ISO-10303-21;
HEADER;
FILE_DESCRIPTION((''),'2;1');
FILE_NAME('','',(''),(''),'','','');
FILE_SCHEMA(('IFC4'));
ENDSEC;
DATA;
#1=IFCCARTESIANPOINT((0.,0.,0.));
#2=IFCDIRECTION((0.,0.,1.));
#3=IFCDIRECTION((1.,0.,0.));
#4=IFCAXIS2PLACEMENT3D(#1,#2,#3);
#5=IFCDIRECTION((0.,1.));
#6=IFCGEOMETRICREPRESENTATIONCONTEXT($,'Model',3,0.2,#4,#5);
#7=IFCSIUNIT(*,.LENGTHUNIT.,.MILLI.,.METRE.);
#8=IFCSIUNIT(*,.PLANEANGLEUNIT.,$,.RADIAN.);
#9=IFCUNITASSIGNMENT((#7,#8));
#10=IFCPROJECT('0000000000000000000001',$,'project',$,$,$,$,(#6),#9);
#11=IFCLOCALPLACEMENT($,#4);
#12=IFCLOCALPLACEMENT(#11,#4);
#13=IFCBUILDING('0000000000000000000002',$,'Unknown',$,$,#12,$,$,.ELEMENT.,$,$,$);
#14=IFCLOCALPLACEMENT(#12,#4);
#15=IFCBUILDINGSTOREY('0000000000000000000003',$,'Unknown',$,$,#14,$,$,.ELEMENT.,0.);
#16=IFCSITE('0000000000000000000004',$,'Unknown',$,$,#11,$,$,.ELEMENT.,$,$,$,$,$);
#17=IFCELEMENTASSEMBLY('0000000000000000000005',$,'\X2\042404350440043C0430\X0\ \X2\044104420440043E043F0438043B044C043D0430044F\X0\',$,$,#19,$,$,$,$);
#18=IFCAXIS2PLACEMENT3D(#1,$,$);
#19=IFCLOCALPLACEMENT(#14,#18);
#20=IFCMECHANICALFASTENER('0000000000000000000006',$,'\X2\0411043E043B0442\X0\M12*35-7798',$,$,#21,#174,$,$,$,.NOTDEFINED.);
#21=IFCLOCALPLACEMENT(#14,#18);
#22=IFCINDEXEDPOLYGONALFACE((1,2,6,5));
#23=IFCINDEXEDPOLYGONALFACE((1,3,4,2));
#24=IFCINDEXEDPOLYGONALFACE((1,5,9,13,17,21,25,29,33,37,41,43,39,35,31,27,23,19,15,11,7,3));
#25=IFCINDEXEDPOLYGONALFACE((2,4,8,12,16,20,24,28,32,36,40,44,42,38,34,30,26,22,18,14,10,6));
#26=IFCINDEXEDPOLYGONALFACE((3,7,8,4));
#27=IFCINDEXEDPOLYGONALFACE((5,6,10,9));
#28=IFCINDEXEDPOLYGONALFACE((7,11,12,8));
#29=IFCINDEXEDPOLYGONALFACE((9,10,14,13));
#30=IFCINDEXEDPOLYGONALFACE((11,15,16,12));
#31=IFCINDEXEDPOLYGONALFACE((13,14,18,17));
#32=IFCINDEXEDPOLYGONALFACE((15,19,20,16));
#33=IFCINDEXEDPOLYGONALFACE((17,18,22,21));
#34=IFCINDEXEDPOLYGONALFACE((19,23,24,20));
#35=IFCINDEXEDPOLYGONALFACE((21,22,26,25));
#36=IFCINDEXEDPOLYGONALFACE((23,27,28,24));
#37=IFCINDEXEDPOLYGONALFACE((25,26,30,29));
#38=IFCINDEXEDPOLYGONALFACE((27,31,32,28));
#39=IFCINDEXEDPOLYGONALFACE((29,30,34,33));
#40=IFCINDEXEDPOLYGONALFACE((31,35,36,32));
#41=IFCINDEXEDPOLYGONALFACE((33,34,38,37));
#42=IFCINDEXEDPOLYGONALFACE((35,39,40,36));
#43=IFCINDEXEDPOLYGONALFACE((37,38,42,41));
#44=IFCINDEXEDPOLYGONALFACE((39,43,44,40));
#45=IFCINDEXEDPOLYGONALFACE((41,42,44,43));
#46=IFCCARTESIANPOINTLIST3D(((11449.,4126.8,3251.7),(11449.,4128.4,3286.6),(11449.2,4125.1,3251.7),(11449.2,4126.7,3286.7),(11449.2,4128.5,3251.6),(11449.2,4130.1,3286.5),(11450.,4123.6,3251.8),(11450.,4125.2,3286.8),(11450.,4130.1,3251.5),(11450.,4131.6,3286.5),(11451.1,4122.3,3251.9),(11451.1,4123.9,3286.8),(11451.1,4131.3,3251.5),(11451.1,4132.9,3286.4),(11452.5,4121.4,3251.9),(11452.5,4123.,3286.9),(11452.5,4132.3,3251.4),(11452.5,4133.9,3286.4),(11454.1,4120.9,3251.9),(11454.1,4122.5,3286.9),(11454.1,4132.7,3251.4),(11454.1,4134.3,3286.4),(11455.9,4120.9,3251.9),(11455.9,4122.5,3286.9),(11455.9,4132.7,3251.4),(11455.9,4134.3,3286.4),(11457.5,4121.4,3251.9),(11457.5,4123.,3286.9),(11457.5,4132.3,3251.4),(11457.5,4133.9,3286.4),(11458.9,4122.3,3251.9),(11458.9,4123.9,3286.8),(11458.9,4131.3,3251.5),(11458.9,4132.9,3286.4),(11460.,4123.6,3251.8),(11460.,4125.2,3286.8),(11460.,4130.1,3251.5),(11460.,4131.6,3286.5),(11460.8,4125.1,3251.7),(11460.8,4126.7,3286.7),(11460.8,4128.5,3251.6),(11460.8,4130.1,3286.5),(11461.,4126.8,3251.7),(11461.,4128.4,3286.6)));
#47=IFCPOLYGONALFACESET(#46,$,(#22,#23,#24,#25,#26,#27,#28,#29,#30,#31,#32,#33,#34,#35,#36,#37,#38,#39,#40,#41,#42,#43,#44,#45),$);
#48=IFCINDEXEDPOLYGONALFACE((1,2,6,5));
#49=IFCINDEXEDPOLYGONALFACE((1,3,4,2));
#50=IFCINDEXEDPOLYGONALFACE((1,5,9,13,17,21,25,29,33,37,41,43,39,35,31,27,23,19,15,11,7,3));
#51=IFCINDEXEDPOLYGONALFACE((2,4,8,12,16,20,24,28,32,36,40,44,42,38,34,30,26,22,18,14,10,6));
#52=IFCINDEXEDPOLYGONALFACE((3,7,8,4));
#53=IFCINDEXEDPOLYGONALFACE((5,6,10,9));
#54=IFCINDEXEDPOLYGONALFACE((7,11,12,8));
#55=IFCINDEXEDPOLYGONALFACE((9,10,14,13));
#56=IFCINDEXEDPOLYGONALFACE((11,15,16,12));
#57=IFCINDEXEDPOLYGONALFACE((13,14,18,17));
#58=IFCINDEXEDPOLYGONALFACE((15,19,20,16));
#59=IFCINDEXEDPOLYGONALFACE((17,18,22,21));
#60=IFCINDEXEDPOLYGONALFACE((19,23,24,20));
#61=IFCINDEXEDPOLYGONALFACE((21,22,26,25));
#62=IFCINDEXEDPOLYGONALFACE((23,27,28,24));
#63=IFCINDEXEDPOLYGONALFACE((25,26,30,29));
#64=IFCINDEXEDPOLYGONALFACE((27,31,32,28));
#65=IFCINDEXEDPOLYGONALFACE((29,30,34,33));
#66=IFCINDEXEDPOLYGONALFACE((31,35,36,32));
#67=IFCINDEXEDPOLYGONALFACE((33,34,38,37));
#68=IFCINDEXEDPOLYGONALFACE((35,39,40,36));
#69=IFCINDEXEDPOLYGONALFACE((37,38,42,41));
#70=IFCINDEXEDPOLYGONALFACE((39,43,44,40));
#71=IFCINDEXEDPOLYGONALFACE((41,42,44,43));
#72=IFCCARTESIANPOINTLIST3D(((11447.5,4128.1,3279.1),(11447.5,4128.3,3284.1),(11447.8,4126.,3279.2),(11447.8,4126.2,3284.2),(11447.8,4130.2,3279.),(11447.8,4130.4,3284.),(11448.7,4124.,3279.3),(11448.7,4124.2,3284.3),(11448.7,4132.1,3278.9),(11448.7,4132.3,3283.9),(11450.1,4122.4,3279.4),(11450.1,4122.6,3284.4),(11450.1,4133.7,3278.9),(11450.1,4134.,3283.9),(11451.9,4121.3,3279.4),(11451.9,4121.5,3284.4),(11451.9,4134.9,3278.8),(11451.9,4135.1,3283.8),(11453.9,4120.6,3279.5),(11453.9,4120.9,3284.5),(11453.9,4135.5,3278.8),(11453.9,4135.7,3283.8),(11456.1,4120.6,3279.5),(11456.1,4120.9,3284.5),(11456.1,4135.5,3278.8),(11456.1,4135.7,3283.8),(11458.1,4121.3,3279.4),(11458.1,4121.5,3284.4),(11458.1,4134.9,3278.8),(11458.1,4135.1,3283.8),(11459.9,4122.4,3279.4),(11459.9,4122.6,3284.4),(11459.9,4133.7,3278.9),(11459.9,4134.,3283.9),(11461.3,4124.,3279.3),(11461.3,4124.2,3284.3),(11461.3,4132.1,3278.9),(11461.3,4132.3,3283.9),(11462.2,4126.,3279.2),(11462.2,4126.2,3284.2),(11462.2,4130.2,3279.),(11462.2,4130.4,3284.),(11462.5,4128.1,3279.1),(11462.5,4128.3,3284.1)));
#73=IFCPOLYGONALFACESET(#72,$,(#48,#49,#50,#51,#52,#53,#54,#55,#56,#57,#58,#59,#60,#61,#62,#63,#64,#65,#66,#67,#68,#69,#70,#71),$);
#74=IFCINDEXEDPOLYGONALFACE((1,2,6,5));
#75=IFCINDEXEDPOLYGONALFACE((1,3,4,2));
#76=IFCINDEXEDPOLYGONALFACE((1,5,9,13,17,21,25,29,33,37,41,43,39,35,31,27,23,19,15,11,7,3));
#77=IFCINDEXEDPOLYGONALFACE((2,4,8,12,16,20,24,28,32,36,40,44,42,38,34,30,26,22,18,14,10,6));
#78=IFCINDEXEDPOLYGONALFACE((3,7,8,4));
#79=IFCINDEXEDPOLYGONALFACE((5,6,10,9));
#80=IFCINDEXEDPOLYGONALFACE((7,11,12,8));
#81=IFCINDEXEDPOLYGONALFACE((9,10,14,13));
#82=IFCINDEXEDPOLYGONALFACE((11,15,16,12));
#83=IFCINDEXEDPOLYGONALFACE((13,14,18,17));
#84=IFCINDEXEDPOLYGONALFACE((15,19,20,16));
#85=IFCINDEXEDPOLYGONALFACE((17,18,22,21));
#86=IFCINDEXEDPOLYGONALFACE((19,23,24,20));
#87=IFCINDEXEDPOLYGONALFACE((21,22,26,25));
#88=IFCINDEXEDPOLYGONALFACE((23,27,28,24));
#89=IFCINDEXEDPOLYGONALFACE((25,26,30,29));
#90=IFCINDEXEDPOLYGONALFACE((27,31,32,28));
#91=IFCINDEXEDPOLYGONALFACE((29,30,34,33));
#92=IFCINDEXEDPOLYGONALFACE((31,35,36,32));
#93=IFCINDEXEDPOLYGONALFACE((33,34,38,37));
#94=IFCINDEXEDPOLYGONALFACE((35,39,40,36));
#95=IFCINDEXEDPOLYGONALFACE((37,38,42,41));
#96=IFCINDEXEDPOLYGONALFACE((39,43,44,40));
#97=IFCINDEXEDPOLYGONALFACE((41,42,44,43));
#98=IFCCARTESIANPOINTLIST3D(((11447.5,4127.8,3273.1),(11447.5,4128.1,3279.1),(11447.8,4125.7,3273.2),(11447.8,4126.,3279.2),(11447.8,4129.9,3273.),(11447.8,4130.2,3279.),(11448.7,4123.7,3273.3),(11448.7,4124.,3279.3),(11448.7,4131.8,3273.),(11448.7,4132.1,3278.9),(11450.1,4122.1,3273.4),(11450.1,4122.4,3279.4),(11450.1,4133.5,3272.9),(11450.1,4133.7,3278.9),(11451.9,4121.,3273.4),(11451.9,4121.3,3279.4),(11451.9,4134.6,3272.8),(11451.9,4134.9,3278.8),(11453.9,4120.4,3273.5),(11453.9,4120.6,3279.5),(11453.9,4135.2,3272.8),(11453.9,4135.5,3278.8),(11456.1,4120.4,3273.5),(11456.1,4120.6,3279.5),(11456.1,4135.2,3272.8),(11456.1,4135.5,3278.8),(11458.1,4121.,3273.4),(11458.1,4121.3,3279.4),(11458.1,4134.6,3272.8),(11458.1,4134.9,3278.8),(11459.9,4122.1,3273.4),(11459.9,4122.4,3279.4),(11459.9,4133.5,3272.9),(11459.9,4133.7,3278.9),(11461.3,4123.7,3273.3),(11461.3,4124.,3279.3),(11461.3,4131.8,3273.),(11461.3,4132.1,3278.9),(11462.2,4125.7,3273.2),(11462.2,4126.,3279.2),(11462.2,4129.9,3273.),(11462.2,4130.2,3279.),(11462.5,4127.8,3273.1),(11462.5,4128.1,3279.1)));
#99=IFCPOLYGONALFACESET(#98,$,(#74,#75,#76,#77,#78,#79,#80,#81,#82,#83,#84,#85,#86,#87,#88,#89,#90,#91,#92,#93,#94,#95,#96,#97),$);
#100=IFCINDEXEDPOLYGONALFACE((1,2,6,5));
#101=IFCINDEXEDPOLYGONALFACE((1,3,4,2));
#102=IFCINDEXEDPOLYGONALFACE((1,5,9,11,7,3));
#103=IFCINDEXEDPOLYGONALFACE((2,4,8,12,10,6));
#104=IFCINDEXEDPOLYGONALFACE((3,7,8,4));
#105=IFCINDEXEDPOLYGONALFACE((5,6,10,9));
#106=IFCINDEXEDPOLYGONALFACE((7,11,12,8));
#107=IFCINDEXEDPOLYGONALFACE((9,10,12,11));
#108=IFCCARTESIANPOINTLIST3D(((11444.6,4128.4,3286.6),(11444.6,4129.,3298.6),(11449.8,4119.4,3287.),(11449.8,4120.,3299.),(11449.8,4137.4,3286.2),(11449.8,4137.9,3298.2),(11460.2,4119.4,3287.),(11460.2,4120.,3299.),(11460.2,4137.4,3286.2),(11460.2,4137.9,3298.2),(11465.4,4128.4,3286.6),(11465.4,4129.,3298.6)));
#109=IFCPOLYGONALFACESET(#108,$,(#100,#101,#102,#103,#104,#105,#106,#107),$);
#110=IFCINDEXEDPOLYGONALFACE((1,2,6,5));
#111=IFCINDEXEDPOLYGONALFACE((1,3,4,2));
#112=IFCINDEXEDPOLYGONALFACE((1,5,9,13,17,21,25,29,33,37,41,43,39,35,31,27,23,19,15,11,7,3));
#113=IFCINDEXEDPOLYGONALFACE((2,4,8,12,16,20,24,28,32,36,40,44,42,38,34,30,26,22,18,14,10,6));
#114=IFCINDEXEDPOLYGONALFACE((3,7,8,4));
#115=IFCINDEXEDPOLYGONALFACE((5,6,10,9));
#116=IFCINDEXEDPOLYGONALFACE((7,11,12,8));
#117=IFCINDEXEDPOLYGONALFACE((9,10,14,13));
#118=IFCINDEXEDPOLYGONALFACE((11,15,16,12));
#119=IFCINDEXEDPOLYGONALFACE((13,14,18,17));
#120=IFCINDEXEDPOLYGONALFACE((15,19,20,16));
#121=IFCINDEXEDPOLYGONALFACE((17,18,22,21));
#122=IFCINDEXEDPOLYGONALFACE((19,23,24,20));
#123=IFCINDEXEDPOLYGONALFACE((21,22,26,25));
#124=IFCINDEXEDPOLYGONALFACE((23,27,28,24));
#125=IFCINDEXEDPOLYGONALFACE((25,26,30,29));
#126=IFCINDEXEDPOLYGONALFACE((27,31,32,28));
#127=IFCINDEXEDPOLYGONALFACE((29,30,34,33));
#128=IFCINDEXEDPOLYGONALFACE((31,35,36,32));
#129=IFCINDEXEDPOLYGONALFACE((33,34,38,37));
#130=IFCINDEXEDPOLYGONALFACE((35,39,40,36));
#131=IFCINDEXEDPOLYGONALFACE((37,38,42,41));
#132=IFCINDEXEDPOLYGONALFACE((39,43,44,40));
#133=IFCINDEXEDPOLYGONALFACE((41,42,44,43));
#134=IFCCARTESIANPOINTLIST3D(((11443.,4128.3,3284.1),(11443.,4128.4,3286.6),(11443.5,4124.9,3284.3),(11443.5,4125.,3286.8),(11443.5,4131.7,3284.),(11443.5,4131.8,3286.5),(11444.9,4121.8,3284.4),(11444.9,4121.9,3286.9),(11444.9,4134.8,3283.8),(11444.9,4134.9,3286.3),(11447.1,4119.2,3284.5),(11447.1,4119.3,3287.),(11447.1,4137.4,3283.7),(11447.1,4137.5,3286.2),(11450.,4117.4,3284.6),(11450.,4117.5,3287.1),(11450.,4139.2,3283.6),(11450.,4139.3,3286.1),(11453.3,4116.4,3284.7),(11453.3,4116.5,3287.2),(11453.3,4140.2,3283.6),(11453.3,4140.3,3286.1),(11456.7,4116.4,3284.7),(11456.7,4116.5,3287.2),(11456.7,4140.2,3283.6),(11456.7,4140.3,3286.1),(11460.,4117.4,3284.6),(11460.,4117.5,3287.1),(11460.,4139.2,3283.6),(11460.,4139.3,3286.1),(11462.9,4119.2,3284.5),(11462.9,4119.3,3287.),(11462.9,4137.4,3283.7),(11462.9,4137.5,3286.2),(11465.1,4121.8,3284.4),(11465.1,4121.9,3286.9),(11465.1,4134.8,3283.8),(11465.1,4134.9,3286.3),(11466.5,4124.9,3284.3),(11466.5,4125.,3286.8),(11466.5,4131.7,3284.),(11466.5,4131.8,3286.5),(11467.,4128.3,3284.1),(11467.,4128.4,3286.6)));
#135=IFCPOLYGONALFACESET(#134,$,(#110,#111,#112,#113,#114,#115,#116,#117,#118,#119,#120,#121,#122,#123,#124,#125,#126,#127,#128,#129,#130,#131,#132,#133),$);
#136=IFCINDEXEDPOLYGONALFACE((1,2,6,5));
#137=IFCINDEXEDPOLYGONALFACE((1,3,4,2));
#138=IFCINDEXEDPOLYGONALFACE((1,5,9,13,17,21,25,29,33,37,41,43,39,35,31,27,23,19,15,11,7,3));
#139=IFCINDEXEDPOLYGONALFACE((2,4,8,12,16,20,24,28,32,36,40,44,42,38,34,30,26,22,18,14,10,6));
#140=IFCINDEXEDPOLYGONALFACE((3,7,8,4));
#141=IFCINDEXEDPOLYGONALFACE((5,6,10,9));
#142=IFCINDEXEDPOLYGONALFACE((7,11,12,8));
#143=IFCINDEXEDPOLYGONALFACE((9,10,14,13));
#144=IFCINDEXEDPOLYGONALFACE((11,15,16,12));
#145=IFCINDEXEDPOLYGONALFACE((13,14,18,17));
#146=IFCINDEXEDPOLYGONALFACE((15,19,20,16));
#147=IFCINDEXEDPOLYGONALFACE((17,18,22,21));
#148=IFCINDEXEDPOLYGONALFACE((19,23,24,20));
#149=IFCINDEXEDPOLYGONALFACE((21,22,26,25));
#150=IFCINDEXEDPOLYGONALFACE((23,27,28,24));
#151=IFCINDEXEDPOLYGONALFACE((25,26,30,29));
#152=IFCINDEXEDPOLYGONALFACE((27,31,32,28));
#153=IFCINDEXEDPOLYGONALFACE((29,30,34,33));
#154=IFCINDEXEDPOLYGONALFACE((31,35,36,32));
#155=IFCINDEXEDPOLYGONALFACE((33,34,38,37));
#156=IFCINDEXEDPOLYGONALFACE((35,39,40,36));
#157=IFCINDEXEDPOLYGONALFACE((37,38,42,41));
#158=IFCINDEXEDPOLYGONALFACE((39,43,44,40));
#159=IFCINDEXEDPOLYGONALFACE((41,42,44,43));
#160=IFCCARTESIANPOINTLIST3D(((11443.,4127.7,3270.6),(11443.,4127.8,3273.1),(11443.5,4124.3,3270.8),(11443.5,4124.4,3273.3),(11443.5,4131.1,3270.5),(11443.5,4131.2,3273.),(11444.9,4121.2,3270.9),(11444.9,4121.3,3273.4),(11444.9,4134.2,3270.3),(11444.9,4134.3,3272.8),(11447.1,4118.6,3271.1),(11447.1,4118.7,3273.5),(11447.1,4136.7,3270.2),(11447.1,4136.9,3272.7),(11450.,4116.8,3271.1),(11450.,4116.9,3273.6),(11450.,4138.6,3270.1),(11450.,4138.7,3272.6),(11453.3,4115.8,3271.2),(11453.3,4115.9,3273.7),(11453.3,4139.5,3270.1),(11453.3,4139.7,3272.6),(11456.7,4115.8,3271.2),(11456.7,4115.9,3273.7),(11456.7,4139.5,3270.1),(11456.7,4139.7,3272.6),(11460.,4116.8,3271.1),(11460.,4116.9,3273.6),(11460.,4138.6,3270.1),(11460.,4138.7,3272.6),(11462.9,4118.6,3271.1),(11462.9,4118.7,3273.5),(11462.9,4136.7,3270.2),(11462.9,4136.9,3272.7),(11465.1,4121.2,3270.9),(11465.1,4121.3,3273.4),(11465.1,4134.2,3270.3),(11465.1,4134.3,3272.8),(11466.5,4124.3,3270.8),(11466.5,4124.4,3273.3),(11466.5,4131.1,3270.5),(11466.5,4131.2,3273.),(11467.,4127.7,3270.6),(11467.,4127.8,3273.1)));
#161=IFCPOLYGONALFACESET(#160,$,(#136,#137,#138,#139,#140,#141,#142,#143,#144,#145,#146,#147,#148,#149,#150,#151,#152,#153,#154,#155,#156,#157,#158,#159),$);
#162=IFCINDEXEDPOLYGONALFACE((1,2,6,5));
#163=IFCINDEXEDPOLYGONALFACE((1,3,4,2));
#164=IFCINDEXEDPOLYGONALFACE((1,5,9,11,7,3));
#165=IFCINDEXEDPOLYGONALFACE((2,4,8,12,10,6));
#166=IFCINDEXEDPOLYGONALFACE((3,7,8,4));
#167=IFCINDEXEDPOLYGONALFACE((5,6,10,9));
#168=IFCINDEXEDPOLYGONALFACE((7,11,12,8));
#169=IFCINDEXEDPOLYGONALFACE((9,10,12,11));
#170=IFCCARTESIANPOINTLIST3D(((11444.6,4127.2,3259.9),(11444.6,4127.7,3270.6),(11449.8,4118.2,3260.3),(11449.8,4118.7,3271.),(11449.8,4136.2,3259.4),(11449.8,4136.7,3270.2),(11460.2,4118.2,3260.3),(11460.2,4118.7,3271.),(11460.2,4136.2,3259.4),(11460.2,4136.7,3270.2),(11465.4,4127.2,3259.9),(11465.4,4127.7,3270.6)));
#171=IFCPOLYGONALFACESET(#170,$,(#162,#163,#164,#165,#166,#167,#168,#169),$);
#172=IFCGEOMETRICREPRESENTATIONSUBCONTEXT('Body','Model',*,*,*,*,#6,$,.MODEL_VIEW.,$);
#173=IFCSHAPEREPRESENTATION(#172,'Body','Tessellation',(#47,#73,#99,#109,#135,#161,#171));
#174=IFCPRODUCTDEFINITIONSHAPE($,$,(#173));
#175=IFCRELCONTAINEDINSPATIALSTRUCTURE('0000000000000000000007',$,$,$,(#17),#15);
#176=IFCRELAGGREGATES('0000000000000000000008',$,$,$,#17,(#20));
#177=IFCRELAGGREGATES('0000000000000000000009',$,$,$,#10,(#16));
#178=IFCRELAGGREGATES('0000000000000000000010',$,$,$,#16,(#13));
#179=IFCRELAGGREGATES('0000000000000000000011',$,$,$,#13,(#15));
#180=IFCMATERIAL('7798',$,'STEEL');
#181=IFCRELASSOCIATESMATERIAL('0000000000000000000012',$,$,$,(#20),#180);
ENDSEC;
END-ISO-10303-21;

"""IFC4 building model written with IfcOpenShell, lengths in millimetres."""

from ifc_helpers import new_model, si_unit, direction, frame, origin_with_axes, place, context, subcontext, project, spatial, line, arc, indexed_curve, outline, extrude, source, transform, mapped, material, element, aggregate, save


model = new_model("IFC4")

# Units and contexts
model_context = context("Model", 3, precision=0.2, world=origin_with_axes(), true_north=direction((0.0, 1.0)))
body_context = subcontext(model_context, "Body", "Model", "MODEL_VIEW")
ifc_project = project(units=[si_unit("LENGTHUNIT", "METRE", prefix="MILLI"), si_unit("PLANEANGLEUNIT", "RADIAN")], contexts=[model_context])

# Site, building, storey
site_placement = place(None, origin_with_axes())
site = spatial("IfcSite", under=ifc_project, at=site_placement, Name="Unknown", CompositionType="ELEMENT")
building_placement = place(site_placement, origin_with_axes())
building = spatial("IfcBuilding", under=site, at=building_placement, Name="Unknown", CompositionType="ELEMENT")
storey_placement = place(building_placement, origin_with_axes())
storey = spatial("IfcBuildingStorey", under=building, at=storey_placement, Name="Unknown", CompositionType="ELEMENT", Elevation=0.0)

# Element assembly
assembly_1_placement = place(storey_placement, frame((11400.0, 88.6, 3426.7), z_axis=(1.0, 0.0, 0.0), x_axis=(0.0, 0.998969, -0.045408)))
assembly_1 = element("IfcElementAssembly", 1, at=assembly_1_placement, inside=storey, Name="Ферма стропильная")

# Mechanical fastener
ifc_material_1 = material(Name="7798", Category="STEEL")
shared_shape_1 = source(origin_with_axes(), body_context, "Body", "SweptSolid", [
    extrude(outline(indexed_curve([(6.0, 0.0), (0.0, 6.0), (-6.0, 0.0), (0.0, -6.0)], segments=[arc(1, 2, 3), arc(3, 4, 1)])), frame((0.0, 0.0, 7.5), z_axis=(0.0, 0.0, -1.0), x_axis=(0.0, 1.0, 0.0)), (0.0, 0.0, 1.0), 35.0),
    extrude(outline(indexed_curve([(7.5, 0.0), (0.0, 7.5), (-7.5, 0.0), (0.0, -7.5)], segments=[arc(1, 2, 3), arc(3, 4, 1)])), frame((0.0, 0.0, 5.0), z_axis=(0.0, 0.0, -1.0), x_axis=(0.0, 1.0, 0.0)), (0.0, 0.0, 1.0), 5.0),
    extrude(outline(indexed_curve([(7.5, 0.0), (0.0, 7.5), (-7.5, 0.0), (0.0, -7.5)], segments=[arc(1, 2, 3), arc(3, 4, 1)])), frame((0.0, 0.0, 0.0), z_axis=(0.0, 0.0, -1.0), x_axis=(0.0, 1.0, 0.0)), (0.0, 0.0, 1.0), 6.0),
    extrude(outline(indexed_curve([(10.4, 0.0), (5.2, 9.0), (-5.2, 9.0), (-10.4, 0.0), (-5.2, -9.0), (5.2, -9.0)], segments=[line(1, 2, 3, 4, 5, 6, 1)])), frame((0.0, 0.0, 19.5), z_axis=(0.0, 0.0, -1.0), x_axis=(0.0, 1.0, 0.0)), (0.0, 0.0, 1.0), 12.0),
    extrude(outline(indexed_curve([(12.0, 0.0), (0.0, 12.0), (-12.0, 0.0), (0.0, -12.0)], segments=[arc(1, 2, 3), arc(3, 4, 1)])), frame((0.0, 0.0, 7.5), z_axis=(0.0, 0.0, -1.0), x_axis=(0.0, 1.0, 0.0)), (0.0, 0.0, 1.0), 2.5),
    extrude(outline(indexed_curve([(12.0, 0.0), (0.0, 12.0), (-12.0, 0.0), (0.0, -12.0)], segments=[arc(1, 2, 3), arc(3, 4, 1)])), frame((0.0, 0.0, -6.0), z_axis=(0.0, 0.0, -1.0), x_axis=(0.0, 1.0, 0.0)), (0.0, 0.0, 1.0), 2.5),
    extrude(outline(indexed_curve([(10.4, 0.0), (5.2, 9.0), (-5.2, 9.0), (-10.4, 0.0), (-5.2, -9.0), (5.2, -9.0)], segments=[line(1, 2, 3, 4, 5, 6, 1)])), frame((0.0, 0.0, -8.5), z_axis=(0.0, 0.0, -1.0), x_axis=(0.0, 1.0, 0.0)), (0.0, 0.0, 1.0), 10.8),
])
mechanical_fastener_1_placement = place(assembly_1_placement, frame((4042.0, 36.0, 55.0), z_axis=(0.0, 1.0, 0.0), x_axis=(1.0, 0.0, 0.0)))
mechanical_fastener_1 = element("IfcMechanicalFastener", 2, at=mechanical_fastener_1_placement, material=ifc_material_1, Name="БолтM12*35-7798", PredefinedType="NOTDEFINED", context=body_context, shape_type="MappedRepresentation", body=[
    mapped(shared_shape_1, transform((0.0, 0.0, 0.0))),
])
aggregate(assembly_1, [mechanical_fastener_1])

save(model, "model.ifc")
